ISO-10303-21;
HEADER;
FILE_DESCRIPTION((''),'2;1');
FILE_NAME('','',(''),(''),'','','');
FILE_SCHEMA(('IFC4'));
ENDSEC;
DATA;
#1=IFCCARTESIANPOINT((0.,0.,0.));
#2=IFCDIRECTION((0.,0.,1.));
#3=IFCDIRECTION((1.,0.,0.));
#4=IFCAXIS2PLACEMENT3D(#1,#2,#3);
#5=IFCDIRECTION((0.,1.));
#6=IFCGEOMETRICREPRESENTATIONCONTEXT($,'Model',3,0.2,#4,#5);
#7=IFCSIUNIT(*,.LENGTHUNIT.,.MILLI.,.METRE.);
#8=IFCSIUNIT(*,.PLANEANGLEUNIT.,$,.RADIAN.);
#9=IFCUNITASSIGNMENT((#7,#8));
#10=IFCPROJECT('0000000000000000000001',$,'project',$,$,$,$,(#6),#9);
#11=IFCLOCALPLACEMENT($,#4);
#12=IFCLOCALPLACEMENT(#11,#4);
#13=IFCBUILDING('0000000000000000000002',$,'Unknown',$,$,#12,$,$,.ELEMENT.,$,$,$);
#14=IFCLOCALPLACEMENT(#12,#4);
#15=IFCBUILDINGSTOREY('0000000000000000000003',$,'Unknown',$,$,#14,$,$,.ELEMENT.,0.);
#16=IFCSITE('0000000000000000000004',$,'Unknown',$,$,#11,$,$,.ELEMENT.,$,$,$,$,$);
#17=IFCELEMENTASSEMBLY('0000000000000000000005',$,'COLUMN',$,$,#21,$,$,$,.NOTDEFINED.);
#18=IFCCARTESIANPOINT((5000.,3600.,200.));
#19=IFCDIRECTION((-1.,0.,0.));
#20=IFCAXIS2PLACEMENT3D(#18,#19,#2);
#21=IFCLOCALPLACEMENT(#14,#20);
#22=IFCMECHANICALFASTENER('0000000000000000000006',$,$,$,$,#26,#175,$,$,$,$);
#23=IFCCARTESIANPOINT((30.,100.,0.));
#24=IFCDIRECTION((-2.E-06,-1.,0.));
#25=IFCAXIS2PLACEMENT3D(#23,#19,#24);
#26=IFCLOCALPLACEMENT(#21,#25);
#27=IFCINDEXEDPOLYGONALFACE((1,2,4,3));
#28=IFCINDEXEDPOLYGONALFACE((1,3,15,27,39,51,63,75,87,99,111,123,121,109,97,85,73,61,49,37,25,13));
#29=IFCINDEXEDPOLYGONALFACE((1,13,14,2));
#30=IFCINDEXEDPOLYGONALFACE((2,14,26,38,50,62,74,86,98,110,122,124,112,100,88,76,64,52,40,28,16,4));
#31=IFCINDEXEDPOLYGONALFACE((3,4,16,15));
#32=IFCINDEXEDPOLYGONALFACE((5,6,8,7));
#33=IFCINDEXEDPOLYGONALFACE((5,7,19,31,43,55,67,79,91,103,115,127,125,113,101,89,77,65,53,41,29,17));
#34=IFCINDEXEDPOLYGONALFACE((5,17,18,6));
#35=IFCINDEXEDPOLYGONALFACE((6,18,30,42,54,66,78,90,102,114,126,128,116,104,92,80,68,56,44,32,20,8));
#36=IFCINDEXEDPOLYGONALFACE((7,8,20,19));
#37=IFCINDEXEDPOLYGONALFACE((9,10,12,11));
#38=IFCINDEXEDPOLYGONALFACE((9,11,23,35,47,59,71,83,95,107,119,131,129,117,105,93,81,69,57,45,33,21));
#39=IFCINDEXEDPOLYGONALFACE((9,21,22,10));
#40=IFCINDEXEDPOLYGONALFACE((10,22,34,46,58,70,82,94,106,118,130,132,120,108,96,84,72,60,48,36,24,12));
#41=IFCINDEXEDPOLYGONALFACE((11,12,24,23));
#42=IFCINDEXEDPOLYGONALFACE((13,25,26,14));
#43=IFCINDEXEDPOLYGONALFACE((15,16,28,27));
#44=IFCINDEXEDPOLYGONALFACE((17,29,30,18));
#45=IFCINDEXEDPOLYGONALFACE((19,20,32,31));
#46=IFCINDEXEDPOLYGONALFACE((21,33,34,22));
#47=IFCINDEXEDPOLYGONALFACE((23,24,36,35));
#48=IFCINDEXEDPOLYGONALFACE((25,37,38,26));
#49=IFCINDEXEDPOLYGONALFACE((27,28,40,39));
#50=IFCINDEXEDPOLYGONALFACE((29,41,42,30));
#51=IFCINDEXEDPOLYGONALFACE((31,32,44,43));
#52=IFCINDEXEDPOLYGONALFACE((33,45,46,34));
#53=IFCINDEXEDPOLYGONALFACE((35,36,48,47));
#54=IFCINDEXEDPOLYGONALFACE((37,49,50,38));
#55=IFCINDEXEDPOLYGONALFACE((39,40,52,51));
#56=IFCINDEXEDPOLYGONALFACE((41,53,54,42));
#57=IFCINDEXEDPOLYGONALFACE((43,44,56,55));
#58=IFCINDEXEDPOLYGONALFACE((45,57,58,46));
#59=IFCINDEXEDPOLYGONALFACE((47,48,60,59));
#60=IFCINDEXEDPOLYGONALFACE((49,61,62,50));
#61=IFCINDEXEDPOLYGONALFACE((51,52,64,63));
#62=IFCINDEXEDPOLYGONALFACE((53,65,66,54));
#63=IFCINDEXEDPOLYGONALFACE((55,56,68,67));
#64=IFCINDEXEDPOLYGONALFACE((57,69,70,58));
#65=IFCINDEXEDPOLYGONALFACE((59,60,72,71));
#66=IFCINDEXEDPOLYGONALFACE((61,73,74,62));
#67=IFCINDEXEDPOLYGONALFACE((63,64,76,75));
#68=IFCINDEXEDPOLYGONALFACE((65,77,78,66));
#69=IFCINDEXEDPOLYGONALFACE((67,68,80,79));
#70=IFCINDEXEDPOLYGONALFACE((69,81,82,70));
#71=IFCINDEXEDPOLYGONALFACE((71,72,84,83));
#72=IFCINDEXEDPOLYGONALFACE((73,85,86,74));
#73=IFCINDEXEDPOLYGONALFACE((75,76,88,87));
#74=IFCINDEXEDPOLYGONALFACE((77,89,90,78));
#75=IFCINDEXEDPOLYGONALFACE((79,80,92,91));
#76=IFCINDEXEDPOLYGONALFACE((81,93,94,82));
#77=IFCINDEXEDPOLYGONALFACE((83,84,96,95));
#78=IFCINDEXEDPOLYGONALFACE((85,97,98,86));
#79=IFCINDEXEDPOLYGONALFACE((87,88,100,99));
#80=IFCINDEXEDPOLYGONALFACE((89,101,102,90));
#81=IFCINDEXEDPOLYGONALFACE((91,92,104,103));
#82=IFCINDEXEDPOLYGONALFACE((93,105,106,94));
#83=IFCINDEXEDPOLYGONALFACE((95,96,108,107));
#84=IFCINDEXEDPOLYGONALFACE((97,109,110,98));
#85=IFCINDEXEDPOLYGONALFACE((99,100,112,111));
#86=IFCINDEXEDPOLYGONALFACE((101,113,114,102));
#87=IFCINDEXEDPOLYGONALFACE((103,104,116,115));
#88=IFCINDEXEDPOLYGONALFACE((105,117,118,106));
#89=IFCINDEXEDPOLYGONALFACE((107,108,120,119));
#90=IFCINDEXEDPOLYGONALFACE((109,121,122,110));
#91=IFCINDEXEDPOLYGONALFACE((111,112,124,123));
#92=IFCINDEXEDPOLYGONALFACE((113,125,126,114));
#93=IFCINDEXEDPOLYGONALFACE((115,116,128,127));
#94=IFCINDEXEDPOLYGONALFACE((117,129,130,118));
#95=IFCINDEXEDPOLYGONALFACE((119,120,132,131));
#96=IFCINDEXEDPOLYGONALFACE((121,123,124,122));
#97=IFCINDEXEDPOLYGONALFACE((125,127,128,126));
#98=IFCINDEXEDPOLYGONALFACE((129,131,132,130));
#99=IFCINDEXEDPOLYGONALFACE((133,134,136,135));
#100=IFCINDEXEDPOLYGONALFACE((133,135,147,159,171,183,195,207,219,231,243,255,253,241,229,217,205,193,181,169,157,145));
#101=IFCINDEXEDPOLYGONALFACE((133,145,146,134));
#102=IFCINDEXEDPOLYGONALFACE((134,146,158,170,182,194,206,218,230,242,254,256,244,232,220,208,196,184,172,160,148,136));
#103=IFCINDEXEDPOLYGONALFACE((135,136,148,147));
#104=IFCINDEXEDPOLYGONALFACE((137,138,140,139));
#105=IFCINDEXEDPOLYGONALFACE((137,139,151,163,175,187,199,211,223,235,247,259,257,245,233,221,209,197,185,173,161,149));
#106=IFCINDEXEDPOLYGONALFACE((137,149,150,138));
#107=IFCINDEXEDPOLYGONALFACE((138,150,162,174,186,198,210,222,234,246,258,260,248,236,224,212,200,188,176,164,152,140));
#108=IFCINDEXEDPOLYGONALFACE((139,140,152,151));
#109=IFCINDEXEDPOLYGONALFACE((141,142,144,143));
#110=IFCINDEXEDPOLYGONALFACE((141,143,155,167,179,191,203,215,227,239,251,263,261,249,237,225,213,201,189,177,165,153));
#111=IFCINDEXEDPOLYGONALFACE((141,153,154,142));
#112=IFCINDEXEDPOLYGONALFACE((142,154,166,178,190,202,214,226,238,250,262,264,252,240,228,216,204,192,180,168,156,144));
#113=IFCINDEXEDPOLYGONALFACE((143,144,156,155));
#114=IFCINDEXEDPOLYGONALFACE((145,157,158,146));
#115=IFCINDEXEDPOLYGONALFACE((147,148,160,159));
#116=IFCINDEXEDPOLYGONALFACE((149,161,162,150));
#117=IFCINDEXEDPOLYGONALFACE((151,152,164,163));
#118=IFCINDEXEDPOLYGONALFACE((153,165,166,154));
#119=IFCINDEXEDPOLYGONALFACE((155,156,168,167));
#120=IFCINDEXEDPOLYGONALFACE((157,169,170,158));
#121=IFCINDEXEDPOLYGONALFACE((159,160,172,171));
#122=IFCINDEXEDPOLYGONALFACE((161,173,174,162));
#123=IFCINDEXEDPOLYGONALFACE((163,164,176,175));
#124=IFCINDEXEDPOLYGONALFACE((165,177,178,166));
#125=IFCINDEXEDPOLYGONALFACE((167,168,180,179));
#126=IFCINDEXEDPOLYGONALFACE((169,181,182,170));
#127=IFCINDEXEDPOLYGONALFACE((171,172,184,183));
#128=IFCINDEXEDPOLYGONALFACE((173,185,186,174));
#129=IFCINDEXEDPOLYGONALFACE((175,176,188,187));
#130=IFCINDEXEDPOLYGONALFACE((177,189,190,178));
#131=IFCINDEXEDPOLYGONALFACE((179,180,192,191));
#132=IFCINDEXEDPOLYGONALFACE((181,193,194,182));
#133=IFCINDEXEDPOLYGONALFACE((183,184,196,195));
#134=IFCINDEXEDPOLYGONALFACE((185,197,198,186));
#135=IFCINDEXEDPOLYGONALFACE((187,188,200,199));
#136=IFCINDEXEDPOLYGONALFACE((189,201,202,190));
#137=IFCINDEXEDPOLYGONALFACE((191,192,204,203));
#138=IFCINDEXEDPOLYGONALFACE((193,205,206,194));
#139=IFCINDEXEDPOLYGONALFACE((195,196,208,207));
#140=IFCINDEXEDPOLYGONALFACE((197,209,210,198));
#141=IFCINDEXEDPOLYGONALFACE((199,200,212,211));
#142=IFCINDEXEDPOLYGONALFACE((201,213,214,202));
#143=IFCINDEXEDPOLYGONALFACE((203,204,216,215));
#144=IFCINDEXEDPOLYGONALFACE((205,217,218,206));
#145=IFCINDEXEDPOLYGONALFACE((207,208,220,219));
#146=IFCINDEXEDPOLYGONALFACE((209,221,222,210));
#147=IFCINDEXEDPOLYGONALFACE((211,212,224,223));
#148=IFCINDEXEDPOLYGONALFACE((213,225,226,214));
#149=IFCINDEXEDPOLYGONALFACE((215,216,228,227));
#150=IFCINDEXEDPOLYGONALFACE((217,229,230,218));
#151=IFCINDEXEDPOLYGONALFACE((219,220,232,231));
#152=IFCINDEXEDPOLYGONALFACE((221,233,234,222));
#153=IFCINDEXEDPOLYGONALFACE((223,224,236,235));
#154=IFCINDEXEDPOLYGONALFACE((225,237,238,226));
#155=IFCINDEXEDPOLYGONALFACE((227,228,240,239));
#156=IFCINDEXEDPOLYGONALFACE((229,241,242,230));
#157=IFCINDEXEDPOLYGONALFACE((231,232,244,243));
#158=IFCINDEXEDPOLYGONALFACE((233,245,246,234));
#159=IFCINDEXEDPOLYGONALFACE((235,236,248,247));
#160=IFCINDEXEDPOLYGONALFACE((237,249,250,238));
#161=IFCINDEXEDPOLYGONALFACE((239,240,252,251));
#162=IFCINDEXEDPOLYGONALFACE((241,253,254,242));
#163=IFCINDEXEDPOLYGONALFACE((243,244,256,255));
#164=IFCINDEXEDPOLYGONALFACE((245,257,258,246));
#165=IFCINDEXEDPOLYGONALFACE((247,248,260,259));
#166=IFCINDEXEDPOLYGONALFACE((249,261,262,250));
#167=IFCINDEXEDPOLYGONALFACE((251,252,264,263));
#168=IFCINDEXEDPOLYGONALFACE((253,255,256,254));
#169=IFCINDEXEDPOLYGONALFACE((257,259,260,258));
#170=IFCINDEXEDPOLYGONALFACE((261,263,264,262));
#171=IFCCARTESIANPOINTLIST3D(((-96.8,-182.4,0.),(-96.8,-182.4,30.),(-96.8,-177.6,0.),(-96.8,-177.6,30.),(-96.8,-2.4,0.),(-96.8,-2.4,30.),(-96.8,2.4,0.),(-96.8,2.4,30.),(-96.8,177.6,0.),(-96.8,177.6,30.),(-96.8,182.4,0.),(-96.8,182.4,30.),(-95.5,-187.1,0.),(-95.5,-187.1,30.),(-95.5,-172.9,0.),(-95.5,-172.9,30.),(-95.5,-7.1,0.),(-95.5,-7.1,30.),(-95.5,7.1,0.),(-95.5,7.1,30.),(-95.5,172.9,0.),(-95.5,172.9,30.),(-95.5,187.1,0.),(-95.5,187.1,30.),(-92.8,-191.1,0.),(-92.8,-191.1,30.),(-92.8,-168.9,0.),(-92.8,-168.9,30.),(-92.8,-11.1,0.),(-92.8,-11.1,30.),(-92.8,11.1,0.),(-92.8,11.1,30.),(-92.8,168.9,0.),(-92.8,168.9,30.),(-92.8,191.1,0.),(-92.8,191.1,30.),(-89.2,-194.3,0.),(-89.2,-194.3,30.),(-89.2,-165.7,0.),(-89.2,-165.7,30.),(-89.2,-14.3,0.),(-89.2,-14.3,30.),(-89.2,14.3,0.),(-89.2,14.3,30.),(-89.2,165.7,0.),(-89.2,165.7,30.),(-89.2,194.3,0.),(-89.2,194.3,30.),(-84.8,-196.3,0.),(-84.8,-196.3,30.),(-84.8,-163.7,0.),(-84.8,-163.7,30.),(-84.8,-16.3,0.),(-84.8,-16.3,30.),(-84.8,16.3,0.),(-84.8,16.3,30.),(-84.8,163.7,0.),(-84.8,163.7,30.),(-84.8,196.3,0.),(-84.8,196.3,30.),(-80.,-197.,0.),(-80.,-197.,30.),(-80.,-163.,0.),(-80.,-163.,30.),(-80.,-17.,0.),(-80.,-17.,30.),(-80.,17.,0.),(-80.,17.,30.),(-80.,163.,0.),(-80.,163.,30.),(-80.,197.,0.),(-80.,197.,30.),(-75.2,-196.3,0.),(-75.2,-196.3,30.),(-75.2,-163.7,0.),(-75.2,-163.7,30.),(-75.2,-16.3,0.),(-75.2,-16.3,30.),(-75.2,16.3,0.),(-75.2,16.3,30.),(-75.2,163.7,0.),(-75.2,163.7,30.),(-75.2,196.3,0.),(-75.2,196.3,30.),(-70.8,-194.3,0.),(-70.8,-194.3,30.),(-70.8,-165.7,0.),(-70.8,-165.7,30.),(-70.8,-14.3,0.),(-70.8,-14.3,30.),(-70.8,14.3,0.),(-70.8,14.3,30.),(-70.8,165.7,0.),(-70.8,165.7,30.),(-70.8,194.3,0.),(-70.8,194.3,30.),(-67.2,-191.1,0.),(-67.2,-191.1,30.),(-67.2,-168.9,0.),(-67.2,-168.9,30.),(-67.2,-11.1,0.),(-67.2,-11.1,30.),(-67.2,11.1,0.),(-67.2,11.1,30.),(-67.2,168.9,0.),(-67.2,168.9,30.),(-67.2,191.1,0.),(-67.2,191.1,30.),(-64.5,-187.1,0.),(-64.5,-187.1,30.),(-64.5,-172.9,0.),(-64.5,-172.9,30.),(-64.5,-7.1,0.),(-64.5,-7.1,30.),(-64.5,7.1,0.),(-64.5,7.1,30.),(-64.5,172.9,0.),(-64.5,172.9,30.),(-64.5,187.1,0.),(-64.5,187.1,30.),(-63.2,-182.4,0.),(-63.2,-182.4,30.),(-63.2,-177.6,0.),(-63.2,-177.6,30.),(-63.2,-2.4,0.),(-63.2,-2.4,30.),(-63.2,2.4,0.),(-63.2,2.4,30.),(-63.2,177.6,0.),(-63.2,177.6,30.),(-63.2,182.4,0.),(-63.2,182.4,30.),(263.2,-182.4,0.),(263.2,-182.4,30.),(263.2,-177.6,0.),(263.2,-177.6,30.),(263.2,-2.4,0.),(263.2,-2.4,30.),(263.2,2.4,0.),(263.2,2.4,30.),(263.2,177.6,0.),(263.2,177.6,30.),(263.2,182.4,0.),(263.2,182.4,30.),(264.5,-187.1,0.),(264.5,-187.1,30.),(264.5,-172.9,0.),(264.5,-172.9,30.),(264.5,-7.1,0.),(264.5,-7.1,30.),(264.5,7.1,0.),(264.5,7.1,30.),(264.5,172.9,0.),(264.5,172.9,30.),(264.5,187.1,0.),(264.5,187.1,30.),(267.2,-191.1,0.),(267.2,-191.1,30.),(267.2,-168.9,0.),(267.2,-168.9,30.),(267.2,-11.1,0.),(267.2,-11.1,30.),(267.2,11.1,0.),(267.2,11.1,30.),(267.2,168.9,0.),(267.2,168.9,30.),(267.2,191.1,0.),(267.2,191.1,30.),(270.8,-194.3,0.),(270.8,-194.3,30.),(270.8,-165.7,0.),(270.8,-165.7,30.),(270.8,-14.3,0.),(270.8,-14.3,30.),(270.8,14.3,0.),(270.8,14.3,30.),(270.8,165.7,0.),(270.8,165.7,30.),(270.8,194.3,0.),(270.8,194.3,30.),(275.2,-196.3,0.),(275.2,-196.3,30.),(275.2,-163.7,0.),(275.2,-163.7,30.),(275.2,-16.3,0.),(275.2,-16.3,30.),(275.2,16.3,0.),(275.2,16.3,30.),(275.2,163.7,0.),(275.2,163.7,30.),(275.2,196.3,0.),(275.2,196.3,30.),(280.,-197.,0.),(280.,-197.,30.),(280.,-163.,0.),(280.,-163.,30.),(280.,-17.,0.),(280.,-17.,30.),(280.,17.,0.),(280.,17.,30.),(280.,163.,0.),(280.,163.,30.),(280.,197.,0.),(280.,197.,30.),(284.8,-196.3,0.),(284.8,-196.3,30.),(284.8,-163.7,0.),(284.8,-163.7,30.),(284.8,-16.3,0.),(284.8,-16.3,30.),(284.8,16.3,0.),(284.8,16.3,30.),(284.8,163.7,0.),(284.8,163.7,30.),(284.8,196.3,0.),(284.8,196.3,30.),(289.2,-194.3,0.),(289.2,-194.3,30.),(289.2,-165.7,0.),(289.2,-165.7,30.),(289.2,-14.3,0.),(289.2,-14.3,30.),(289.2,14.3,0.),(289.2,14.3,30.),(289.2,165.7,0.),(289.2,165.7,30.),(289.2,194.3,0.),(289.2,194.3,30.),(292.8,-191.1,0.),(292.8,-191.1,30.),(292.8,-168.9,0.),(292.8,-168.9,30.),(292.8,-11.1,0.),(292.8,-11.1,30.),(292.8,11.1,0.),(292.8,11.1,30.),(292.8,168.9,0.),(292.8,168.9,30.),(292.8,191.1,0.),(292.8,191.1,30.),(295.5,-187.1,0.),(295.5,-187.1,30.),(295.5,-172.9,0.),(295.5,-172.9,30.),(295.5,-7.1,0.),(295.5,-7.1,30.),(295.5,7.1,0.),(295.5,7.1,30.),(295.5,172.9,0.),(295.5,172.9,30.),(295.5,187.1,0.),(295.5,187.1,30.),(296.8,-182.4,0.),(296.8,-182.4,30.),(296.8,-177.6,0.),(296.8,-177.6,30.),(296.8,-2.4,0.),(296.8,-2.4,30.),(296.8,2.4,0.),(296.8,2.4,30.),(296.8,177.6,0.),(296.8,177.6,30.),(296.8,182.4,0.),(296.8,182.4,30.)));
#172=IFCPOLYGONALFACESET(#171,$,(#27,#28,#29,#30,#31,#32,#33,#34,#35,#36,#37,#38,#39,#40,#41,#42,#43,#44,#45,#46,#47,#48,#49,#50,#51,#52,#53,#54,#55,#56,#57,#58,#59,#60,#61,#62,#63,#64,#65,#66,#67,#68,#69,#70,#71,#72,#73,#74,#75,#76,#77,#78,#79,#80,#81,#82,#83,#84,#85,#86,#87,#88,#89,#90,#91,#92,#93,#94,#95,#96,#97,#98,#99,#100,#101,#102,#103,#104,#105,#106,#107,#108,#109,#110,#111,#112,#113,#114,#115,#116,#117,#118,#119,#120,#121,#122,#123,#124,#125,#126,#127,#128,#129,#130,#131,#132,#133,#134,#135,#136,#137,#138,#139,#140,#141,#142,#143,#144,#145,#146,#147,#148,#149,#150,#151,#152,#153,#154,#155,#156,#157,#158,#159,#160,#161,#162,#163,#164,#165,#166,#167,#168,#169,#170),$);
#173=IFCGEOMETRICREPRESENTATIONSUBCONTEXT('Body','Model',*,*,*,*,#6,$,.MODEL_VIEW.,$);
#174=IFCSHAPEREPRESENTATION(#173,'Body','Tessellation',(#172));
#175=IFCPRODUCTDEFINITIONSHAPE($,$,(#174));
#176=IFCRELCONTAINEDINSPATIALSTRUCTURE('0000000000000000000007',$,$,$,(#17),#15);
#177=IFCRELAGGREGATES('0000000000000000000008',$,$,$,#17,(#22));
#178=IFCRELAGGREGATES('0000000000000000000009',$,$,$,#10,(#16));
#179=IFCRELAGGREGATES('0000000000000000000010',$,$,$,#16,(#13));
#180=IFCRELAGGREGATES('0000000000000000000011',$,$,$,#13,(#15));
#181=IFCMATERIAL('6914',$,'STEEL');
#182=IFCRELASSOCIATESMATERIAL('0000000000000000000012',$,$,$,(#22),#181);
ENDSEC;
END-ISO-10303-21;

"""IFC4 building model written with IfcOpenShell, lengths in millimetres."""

from ifc_helpers import new_model, si_unit, direction, frame, origin_with_axes, place, context, subcontext, project, spatial, arc, indexed_curve, outline, extrude, source, transform, mapped, material, element, aggregate, save


model = new_model("IFC4")

# Units and contexts
model_context = context("Model", 3, precision=0.2, world=origin_with_axes(), true_north=direction((0.0, 1.0)))
body_context = subcontext(model_context, "Body", "Model", "MODEL_VIEW")
ifc_project = project(units=[si_unit("LENGTHUNIT", "METRE", prefix="MILLI"), si_unit("PLANEANGLEUNIT", "RADIAN")], contexts=[model_context])

# Site, building, storey
site_placement = place(None, origin_with_axes())
site = spatial("IfcSite", under=ifc_project, at=site_placement, Name="Unknown", CompositionType="ELEMENT")
building_placement = place(site_placement, origin_with_axes())
building = spatial("IfcBuilding", under=site, at=building_placement, Name="Unknown", CompositionType="ELEMENT")
storey_placement = place(building_placement, origin_with_axes())
storey = spatial("IfcBuildingStorey", under=building, at=storey_placement, Name="Unknown", CompositionType="ELEMENT", Elevation=0.0)

# Element assembly
assembly_1_placement = place(storey_placement, frame((5000.0, 3600.0, 200.0), z_axis=(-1.0, 0.0, 0.0), x_axis=(0.0, 0.0, 1.0)))
assembly_1 = element("IfcElementAssembly", 1, at=assembly_1_placement, inside=storey, Name="COLUMN", PredefinedType="NOTDEFINED")

# Shared definitions
ifc_material_1 = material(Name="6914", Category="STEEL")

# Mechanical fastener
shared_shape_1 = source(origin_with_axes(), body_context, "Body", "SweptSolid", [
    extrude(outline(indexed_curve([(17.0, 0.0), (0.0, 17.0), (-17.0, 0.0), (0.0, -17.0)], segments=[arc(1, 2, 3), arc(3, 4, 1)])), frame((0.0, 0.0, 30.0), z_axis=(0.0, -0.000002, -1.0), x_axis=(0.0, 1.0, 0.0)), (0.0, 0.0, 1.0), 30.0),
])
mechanical_fastener_1_placement = place(assembly_1_placement, frame((30.0, 100.0, 0.0), z_axis=(-1.0, 0.0, 0.0), x_axis=(-0.000002, -1.0, 0.0)))
mechanical_fastener_1 = element("IfcMechanicalFastener", 2, at=mechanical_fastener_1_placement, material=ifc_material_1, context=body_context, shape_type="MappedRepresentation", body=[
    mapped(shared_shape_1, transform((-80.0, -180.0, 0.0))),
    mapped(shared_shape_1, transform((-80.0, 0.0, 0.0))),
    mapped(shared_shape_1, transform((-80.0, 180.0, 0.0))),
    mapped(shared_shape_1, transform((280.0, -180.0, 0.0))),
    mapped(shared_shape_1, transform((280.0, 0.0, 0.0))),
    mapped(shared_shape_1, transform((280.0, 180.0, 0.0))),
])
aggregate(assembly_1, [mechanical_fastener_1])

save(model, "model.ifc")
